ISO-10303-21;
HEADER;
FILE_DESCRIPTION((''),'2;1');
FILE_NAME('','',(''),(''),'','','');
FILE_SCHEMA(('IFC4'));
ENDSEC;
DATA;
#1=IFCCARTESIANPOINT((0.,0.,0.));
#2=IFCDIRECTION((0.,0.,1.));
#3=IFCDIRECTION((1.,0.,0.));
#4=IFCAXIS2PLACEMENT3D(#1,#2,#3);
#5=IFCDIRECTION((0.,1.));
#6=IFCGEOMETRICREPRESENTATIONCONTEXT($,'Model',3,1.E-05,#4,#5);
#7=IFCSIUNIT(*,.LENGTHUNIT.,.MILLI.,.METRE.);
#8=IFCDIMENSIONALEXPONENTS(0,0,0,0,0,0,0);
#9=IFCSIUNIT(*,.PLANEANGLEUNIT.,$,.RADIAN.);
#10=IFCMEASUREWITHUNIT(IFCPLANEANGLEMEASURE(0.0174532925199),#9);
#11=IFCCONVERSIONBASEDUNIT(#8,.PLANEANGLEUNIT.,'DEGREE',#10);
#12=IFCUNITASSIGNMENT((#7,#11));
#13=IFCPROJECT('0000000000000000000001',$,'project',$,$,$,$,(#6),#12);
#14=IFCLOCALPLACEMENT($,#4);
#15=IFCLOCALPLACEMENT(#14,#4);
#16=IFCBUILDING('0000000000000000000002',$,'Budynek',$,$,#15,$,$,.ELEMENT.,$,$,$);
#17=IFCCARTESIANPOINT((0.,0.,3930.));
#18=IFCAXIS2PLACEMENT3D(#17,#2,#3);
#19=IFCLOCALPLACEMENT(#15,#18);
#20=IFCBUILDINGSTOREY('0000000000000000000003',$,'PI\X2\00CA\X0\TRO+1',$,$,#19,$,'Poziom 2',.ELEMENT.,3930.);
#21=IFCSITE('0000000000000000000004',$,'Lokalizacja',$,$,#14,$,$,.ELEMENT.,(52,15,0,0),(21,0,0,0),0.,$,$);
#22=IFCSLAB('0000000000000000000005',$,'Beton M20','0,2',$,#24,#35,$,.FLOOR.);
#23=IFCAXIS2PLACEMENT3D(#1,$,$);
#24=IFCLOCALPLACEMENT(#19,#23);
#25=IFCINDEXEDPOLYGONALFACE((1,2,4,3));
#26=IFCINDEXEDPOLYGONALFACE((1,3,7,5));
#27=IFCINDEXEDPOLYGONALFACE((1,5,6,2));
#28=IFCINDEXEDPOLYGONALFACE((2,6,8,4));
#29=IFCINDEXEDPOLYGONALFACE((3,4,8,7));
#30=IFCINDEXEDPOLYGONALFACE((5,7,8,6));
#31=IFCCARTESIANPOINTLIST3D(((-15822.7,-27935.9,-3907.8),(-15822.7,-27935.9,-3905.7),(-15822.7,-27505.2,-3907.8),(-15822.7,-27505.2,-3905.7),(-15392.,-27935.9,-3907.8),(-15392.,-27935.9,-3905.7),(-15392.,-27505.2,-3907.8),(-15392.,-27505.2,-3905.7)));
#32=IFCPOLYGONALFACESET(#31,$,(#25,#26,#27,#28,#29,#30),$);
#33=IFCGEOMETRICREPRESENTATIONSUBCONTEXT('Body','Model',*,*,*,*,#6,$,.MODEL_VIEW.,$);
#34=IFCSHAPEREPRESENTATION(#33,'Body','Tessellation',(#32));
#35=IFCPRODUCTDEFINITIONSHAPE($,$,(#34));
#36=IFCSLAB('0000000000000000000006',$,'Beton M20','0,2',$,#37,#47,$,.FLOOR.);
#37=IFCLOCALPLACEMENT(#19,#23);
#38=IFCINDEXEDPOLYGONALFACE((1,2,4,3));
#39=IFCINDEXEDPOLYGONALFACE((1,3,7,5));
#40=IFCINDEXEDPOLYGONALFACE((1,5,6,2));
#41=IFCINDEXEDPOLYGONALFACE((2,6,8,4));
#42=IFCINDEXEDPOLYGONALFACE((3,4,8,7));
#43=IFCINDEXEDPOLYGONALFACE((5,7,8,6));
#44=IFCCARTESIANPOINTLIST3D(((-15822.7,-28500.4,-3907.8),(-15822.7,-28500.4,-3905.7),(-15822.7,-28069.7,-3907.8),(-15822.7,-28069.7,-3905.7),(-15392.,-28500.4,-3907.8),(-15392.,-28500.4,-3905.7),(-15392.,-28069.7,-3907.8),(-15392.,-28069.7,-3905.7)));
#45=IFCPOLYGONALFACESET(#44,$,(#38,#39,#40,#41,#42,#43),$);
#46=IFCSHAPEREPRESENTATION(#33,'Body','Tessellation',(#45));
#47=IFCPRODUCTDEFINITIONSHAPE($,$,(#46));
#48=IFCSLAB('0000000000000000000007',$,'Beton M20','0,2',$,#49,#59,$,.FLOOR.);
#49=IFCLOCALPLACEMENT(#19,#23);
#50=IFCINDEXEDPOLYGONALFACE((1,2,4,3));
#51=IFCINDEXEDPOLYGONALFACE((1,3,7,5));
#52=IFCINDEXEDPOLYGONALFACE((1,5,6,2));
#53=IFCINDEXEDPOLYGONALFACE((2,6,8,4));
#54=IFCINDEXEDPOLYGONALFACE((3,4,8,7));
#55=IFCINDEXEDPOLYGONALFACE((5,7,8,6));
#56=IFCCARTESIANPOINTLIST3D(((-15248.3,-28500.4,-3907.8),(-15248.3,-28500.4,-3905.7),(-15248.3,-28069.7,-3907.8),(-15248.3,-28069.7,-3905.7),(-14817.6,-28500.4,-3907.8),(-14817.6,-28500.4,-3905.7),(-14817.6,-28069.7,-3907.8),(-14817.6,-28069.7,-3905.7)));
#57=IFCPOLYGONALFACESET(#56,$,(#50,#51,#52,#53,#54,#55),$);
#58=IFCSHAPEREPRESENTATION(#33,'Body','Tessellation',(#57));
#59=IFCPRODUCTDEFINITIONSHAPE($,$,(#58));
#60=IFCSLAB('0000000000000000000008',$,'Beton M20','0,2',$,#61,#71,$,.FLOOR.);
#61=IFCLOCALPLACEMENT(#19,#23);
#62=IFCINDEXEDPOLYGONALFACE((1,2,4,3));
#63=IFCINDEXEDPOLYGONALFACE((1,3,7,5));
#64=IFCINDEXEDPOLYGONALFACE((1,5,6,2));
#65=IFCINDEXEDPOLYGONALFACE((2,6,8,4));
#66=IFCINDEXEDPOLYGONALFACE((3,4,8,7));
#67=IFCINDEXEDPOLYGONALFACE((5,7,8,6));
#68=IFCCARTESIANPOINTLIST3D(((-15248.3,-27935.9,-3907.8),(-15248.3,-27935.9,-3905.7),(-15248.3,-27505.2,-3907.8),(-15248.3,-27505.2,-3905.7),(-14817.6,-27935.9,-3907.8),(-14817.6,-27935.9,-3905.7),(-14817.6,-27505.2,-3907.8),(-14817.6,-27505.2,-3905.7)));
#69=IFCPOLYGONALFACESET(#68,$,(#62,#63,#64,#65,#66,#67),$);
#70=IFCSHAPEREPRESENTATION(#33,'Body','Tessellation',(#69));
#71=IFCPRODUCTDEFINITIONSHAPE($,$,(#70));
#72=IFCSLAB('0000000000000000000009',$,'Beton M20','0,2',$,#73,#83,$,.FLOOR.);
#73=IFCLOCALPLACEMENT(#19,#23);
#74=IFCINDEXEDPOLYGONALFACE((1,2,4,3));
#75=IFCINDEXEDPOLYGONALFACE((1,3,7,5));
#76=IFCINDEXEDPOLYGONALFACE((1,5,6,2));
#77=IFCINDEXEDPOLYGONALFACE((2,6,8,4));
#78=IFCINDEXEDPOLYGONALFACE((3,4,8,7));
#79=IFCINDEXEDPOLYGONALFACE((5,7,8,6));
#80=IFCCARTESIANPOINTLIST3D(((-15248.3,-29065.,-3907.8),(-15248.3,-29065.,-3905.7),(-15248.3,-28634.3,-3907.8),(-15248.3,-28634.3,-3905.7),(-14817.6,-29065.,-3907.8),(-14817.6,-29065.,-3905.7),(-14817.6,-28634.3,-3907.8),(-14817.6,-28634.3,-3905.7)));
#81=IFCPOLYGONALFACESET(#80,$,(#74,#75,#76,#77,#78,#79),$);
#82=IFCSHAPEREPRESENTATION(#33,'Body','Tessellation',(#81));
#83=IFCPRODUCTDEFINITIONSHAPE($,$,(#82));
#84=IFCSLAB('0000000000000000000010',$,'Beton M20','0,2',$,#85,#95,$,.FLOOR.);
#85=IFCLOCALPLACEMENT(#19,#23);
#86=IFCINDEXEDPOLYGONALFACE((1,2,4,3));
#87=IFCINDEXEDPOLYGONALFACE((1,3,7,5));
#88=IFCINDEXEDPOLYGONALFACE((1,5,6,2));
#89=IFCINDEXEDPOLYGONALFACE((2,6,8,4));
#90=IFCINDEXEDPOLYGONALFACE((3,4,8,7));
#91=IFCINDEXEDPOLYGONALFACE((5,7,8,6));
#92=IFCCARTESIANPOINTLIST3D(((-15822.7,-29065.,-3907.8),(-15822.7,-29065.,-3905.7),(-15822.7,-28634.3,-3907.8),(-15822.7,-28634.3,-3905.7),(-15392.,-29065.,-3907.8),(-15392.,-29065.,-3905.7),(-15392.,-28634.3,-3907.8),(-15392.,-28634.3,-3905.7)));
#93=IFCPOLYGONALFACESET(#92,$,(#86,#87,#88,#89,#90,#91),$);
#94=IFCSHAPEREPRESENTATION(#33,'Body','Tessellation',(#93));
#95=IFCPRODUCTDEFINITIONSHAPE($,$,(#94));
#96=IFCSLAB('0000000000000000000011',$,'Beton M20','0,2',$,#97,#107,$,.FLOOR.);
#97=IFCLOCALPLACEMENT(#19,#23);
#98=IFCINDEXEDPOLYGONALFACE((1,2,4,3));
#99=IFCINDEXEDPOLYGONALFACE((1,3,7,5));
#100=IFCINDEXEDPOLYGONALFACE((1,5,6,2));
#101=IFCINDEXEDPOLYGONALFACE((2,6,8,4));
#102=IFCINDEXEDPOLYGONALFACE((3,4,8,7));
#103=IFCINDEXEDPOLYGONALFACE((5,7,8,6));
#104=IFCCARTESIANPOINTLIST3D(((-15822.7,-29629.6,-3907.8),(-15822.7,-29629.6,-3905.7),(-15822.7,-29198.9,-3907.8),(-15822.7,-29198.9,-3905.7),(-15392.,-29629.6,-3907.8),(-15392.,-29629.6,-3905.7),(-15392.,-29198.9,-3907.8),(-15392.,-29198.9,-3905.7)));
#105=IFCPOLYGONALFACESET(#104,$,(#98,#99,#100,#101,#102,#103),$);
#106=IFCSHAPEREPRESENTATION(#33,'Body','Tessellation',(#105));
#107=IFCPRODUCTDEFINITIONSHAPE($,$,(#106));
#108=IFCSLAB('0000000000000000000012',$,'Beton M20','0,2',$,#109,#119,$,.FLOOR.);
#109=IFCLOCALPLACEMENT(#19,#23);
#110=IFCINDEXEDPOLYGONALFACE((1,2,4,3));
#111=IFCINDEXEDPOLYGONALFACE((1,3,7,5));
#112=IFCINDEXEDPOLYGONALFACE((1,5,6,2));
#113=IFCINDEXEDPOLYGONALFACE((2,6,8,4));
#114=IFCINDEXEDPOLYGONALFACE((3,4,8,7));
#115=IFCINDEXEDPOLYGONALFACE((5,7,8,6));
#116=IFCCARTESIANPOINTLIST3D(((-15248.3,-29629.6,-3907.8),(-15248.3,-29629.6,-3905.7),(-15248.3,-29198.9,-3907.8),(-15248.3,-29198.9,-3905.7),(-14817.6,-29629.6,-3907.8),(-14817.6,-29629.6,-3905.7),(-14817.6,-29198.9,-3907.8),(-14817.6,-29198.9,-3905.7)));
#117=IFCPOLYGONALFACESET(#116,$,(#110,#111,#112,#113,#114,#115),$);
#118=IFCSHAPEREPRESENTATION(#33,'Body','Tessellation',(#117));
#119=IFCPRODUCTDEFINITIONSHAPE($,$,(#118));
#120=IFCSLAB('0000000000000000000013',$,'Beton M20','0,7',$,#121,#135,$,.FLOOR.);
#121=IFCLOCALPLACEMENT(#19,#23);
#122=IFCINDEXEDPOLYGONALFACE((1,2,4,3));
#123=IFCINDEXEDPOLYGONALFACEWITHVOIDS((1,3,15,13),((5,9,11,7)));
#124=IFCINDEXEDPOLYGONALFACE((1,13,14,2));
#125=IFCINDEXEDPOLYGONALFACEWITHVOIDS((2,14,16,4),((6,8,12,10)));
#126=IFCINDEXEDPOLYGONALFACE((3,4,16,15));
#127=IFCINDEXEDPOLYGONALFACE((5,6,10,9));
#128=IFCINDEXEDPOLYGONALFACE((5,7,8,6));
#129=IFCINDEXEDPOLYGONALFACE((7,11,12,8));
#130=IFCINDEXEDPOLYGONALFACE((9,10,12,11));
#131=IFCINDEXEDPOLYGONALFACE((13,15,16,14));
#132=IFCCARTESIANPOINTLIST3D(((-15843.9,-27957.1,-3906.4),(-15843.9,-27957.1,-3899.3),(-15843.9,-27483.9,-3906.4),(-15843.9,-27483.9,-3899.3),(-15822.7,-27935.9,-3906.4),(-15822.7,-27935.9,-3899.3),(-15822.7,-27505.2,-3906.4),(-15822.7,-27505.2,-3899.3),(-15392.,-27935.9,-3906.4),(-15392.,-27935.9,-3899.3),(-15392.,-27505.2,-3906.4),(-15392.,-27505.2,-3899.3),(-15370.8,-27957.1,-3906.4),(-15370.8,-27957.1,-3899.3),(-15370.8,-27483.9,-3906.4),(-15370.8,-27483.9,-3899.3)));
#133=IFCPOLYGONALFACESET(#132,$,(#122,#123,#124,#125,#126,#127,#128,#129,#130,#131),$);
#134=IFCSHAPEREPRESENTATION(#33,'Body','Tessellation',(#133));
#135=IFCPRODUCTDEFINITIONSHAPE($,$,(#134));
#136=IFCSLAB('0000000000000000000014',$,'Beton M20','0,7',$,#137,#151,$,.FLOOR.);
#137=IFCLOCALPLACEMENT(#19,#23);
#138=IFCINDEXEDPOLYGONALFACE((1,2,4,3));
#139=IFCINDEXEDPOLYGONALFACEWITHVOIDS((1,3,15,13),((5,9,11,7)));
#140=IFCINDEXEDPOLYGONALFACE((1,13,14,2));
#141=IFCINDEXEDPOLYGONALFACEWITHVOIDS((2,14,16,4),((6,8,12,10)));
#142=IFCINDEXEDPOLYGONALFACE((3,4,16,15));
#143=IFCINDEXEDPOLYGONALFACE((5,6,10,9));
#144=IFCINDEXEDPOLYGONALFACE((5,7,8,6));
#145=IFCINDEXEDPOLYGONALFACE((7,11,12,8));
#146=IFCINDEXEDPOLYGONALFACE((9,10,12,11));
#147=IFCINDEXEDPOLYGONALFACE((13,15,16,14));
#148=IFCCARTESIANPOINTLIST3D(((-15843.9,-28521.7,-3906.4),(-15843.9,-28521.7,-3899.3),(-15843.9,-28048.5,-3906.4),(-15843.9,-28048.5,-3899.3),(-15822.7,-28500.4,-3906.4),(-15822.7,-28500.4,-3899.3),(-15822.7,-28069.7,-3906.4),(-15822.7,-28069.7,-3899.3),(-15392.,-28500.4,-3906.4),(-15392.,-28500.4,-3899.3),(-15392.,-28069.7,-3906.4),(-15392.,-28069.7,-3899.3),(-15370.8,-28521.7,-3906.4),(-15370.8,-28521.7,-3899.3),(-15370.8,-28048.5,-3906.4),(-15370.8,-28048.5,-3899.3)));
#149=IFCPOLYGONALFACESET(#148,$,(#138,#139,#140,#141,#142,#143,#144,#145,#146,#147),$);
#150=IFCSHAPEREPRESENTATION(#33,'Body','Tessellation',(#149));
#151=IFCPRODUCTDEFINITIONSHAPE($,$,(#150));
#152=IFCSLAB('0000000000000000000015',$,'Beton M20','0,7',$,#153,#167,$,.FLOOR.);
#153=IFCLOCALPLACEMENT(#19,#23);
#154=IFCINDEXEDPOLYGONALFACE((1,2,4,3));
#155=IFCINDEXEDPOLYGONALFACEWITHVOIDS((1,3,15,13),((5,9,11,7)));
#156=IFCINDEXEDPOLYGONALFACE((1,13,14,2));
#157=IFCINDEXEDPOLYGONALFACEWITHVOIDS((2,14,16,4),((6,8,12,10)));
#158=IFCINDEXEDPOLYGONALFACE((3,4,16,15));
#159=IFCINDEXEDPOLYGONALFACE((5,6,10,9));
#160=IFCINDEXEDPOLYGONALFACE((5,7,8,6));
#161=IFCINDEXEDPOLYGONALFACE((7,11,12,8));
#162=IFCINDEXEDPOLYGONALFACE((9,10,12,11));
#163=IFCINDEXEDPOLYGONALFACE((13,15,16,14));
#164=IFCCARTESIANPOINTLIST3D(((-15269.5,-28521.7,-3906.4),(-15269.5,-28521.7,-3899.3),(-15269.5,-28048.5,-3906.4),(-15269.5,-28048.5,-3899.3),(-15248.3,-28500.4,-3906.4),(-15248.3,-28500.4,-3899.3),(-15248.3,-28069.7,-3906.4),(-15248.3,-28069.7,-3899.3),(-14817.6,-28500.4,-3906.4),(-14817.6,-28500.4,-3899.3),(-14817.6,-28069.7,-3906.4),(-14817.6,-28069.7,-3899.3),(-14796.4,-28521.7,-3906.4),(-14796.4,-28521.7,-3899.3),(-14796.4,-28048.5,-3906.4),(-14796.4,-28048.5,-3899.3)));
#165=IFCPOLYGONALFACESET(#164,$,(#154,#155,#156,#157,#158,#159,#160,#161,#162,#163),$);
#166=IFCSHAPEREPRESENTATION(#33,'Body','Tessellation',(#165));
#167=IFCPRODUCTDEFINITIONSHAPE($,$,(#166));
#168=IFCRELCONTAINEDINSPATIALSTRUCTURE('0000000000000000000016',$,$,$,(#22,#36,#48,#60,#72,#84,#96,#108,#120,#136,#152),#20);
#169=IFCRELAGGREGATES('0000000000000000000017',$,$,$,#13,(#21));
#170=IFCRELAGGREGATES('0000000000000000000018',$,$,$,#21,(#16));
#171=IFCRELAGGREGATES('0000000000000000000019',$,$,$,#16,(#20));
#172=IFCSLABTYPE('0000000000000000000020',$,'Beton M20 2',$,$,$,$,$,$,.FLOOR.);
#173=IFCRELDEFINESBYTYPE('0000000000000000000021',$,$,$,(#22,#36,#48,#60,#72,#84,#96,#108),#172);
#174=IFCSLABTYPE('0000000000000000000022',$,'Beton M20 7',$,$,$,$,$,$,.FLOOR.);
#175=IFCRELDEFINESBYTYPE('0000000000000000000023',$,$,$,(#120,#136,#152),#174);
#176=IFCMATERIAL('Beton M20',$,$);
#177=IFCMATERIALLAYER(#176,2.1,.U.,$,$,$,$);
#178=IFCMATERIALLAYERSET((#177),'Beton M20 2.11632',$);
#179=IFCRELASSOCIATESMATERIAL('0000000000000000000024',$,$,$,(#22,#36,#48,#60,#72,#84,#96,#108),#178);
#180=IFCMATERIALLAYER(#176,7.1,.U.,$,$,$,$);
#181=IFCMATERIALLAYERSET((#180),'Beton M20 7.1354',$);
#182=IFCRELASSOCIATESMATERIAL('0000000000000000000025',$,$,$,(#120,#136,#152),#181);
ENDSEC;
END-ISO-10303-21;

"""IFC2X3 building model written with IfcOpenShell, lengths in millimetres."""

from ifc_helpers import new_model, entity, si_unit, converted_unit, direction, frame, origin_with_axes, place, context, subcontext, project, spatial, polyline, outline, extrude, material, layer, layer_set, layer_usage, type_object, element, save


model = new_model("IFC2X3")

# Units and contexts
model_context = context("Model", 3, precision=1e-05, world=origin_with_axes(), true_north=direction((0.0, 1.0)))
body_context = subcontext(model_context, "Body", "Model", "MODEL_VIEW")
ifc_project = project(units=[si_unit("LENGTHUNIT", "METRE", prefix="MILLI"), converted_unit("PLANEANGLEUNIT", "DEGREE", entity("IfcPlaneAngleMeasure", 0.0174532925199), si_unit("PLANEANGLEUNIT", "RADIAN"), dimensions=[0, 0, 0, 0, 0, 0, 0])], contexts=[model_context])

# Site, building, storey
site_placement = place(None, origin_with_axes())
site = spatial("IfcSite", under=ifc_project, at=site_placement, Name="Lokalizacja", CompositionType="ELEMENT", RefLatitude=(52, 15, 0, 0), RefLongitude=(21, 0, 0, 0), RefElevation=0.0)
building_placement = place(site_placement, origin_with_axes())
building = spatial("IfcBuilding", under=site, at=building_placement, Name="Budynek", CompositionType="ELEMENT")
storey_placement = place(building_placement, frame((0.0, 0.0, 3930.0), z_axis=(0.0, 0.0, 1.0), x_axis=(1.0, 0.0, 0.0)))
storey = spatial("IfcBuildingStorey", under=building, at=storey_placement, Name="PIÊTRO+1", LongName="Poziom 2", CompositionType="ELEMENT", Elevation=3930.0)

# Slabs
ifc_material_1 = material(Name="Beton M20")
ifc_layer_1 = layer(ifc_material_1, 2.1, ventilated="UNKNOWN")
ifc_layer_set_1 = layer_set([ifc_layer_1], Name="Beton M20 2.11632")
ifc_layer_usage_1 = layer_usage(ifc_layer_set_1, "AXIS3", "NEGATIVE", 2.1)
slab_type_1 = type_object("IfcSlabType", Name="Beton M20 2", PredefinedType="FLOOR")
slab_1_placement = place(storey_placement, frame((-15822.7, -27505.2, -3905.7), z_axis=(0.0, 0.0, 1.0), x_axis=(1.0, 0.0, 0.0)))
element("IfcSlab", 1, at=slab_1_placement, inside=storey, type_object=slab_type_1, material=ifc_layer_usage_1, Name="Beton M20", Description="0,2", PredefinedType="FLOOR", context=body_context, shape_type="SweptSolid", body=[
    extrude(outline(polyline([(0.0, 0.0), (0.0, -430.7), (430.7, -430.7), (430.7, 0.0), (0.0, 0.0)])), frame((0.0, 0.0, -2.1), z_axis=(0.0, 0.0, 1.0), x_axis=(1.0, 0.0, 0.0)), (0.0, 0.0, 1.0), 2.1),
])
ifc_layer_usage_2 = layer_usage(ifc_layer_set_1, "AXIS3", "NEGATIVE", 2.1)
slab_2_placement = place(storey_placement, frame((-15822.7, -28069.7, -3905.7), z_axis=(0.0, 0.0, 1.0), x_axis=(1.0, 0.0, 0.0)))
element("IfcSlab", 2, at=slab_2_placement, inside=storey, type_object=slab_type_1, material=ifc_layer_usage_2, Name="Beton M20", Description="0,2", PredefinedType="FLOOR", context=body_context, shape_type="SweptSolid", body=[
    extrude(outline(polyline([(0.0, 0.0), (0.0, -430.7), (430.7, -430.7), (430.7, 0.0), (0.0, 0.0)])), frame((0.0, 0.0, -2.1), z_axis=(0.0, 0.0, 1.0), x_axis=(1.0, 0.0, 0.0)), (0.0, 0.0, 1.0), 2.1),
])
ifc_layer_usage_3 = layer_usage(ifc_layer_set_1, "AXIS3", "NEGATIVE", 2.1)
slab_3_placement = place(storey_placement, frame((-15248.3, -28069.7, -3905.7), z_axis=(0.0, 0.0, 1.0), x_axis=(1.0, 0.0, 0.0)))
element("IfcSlab", 3, at=slab_3_placement, inside=storey, type_object=slab_type_1, material=ifc_layer_usage_3, Name="Beton M20", Description="0,2", PredefinedType="FLOOR", context=body_context, shape_type="SweptSolid", body=[
    extrude(outline(polyline([(0.0, 0.0), (0.0, -430.7), (430.7, -430.7), (430.7, 0.0), (0.0, 0.0)])), frame((0.0, 0.0, -2.1), z_axis=(0.0, 0.0, 1.0), x_axis=(1.0, 0.0, 0.0)), (0.0, 0.0, 1.0), 2.1),
])
ifc_layer_usage_4 = layer_usage(ifc_layer_set_1, "AXIS3", "NEGATIVE", 2.1)
slab_4_placement = place(storey_placement, frame((-15248.3, -27505.2, -3905.7), z_axis=(0.0, 0.0, 1.0), x_axis=(1.0, 0.0, 0.0)))
element("IfcSlab", 4, at=slab_4_placement, inside=storey, type_object=slab_type_1, material=ifc_layer_usage_4, Name="Beton M20", Description="0,2", PredefinedType="FLOOR", context=body_context, shape_type="SweptSolid", body=[
    extrude(outline(polyline([(0.0, 0.0), (0.0, -430.7), (430.7, -430.7), (430.7, 0.0), (0.0, 0.0)])), frame((0.0, 0.0, -2.1), z_axis=(0.0, 0.0, 1.0), x_axis=(1.0, 0.0, 0.0)), (0.0, 0.0, 1.0), 2.1),
])
ifc_layer_usage_5 = layer_usage(ifc_layer_set_1, "AXIS3", "NEGATIVE", 2.1)
slab_5_placement = place(storey_placement, frame((-15248.3, -28634.3, -3905.7), z_axis=(0.0, 0.0, 1.0), x_axis=(1.0, 0.0, 0.0)))
element("IfcSlab", 5, at=slab_5_placement, inside=storey, type_object=slab_type_1, material=ifc_layer_usage_5, Name="Beton M20", Description="0,2", PredefinedType="FLOOR", context=body_context, shape_type="SweptSolid", body=[
    extrude(outline(polyline([(0.0, 0.0), (0.0, -430.7), (430.7, -430.7), (430.7, 0.0), (0.0, 0.0)])), frame((0.0, 0.0, -2.1), z_axis=(0.0, 0.0, 1.0), x_axis=(1.0, 0.0, 0.0)), (0.0, 0.0, 1.0), 2.1),
])
ifc_layer_usage_6 = layer_usage(ifc_layer_set_1, "AXIS3", "NEGATIVE", 2.1)
slab_6_placement = place(storey_placement, frame((-15822.7, -28634.3, -3905.7), z_axis=(0.0, 0.0, 1.0), x_axis=(1.0, 0.0, 0.0)))
element("IfcSlab", 6, at=slab_6_placement, inside=storey, type_object=slab_type_1, material=ifc_layer_usage_6, Name="Beton M20", Description="0,2", PredefinedType="FLOOR", context=body_context, shape_type="SweptSolid", body=[
    extrude(outline(polyline([(0.0, 0.0), (0.0, -430.7), (430.7, -430.7), (430.7, 0.0), (0.0, 0.0)])), frame((0.0, 0.0, -2.1), z_axis=(0.0, 0.0, 1.0), x_axis=(1.0, 0.0, 0.0)), (0.0, 0.0, 1.0), 2.1),
])
ifc_layer_usage_7 = layer_usage(ifc_layer_set_1, "AXIS3", "NEGATIVE", 2.1)
slab_7_placement = place(storey_placement, frame((-15822.7, -29198.9, -3905.7), z_axis=(0.0, 0.0, 1.0), x_axis=(1.0, 0.0, 0.0)))
element("IfcSlab", 7, at=slab_7_placement, inside=storey, type_object=slab_type_1, material=ifc_layer_usage_7, Name="Beton M20", Description="0,2", PredefinedType="FLOOR", context=body_context, shape_type="SweptSolid", body=[
    extrude(outline(polyline([(0.0, 0.0), (0.0, -430.7), (430.7, -430.7), (430.7, 0.0), (0.0, 0.0)])), frame((0.0, 0.0, -2.1), z_axis=(0.0, 0.0, 1.0), x_axis=(1.0, 0.0, 0.0)), (0.0, 0.0, 1.0), 2.1),
])
ifc_layer_usage_8 = layer_usage(ifc_layer_set_1, "AXIS3", "NEGATIVE", 2.1)
slab_8_placement = place(storey_placement, frame((-15248.3, -29198.9, -3905.7), z_axis=(0.0, 0.0, 1.0), x_axis=(1.0, 0.0, 0.0)))
element("IfcSlab", 8, at=slab_8_placement, inside=storey, type_object=slab_type_1, material=ifc_layer_usage_8, Name="Beton M20", Description="0,2", PredefinedType="FLOOR", context=body_context, shape_type="SweptSolid", body=[
    extrude(outline(polyline([(0.0, 0.0), (0.0, -430.7), (430.7, -430.7), (430.7, 0.0), (0.0, 0.0)])), frame((0.0, 0.0, -2.1), z_axis=(0.0, 0.0, 1.0), x_axis=(1.0, 0.0, 0.0)), (0.0, 0.0, 1.0), 2.1),
])

# Slabs, openings
ifc_layer_2 = layer(ifc_material_1, 7.1, ventilated="UNKNOWN")
ifc_layer_set_2 = layer_set([ifc_layer_2], Name="Beton M20 7.1354")
ifc_layer_usage_9 = layer_usage(ifc_layer_set_2, "AXIS3", "NEGATIVE", 7.1)
slab_type_2 = type_object("IfcSlabType", Name="Beton M20 7", PredefinedType="FLOOR")
slab_9_placement = place(storey_placement, frame((-15843.9, -27483.9, -3899.3), z_axis=(0.0, 0.0, 1.0), x_axis=(1.0, 0.0, 0.0)))
slab_9 = element("IfcSlab", 9, at=slab_9_placement, inside=storey, type_object=slab_type_2, material=ifc_layer_usage_9, Name="Beton M20", Description="0,7", PredefinedType="FLOOR", context=body_context, shape_type="SweptSolid", body=[
    extrude(outline(polyline([(0.0, 0.0), (0.0, -473.1), (473.1, -473.1), (473.1, 0.0), (0.0, 0.0)])), frame((0.0, 0.0, -7.1), z_axis=(0.0, 0.0, 1.0), x_axis=(1.0, 0.0, 0.0)), (0.0, 0.0, 1.0), 7.1),
])
opening_1_placement = place(slab_9_placement, origin_with_axes())
element("IfcOpeningElement", 10, at=opening_1_placement, cuts=slab_9, context=body_context, shape_type="SweptSolid", body=[
    extrude(outline(polyline([(21.2, -21.2), (21.2, -451.9), (451.9, -451.9), (451.9, -21.2), (21.2, -21.2)])), frame((0.0, 0.0, -7.1), z_axis=(0.0, 0.0, 1.0), x_axis=(1.0, 0.0, 0.0)), (0.0, 0.0, 1.0), 7.1),
])
ifc_layer_usage_10 = layer_usage(ifc_layer_set_2, "AXIS3", "NEGATIVE", 7.1)
slab_10_placement = place(storey_placement, frame((-15843.9, -28048.5, -3899.3), z_axis=(0.0, 0.0, 1.0), x_axis=(1.0, 0.0, 0.0)))
slab_10 = element("IfcSlab", 11, at=slab_10_placement, inside=storey, type_object=slab_type_2, material=ifc_layer_usage_10, Name="Beton M20", Description="0,7", PredefinedType="FLOOR", context=body_context, shape_type="SweptSolid", body=[
    extrude(outline(polyline([(0.0, 0.0), (0.0, -473.1), (473.1, -473.1), (473.1, 0.0), (0.0, 0.0)])), frame((0.0, 0.0, -7.1), z_axis=(0.0, 0.0, 1.0), x_axis=(1.0, 0.0, 0.0)), (0.0, 0.0, 1.0), 7.1),
])
opening_2_placement = place(slab_10_placement, origin_with_axes())
element("IfcOpeningElement", 12, at=opening_2_placement, cuts=slab_10, context=body_context, shape_type="SweptSolid", body=[
    extrude(outline(polyline([(21.2, -21.2), (21.2, -451.9), (451.9, -451.9), (451.9, -21.2), (21.2, -21.2)])), frame((0.0, 0.0, -7.1), z_axis=(0.0, 0.0, 1.0), x_axis=(1.0, 0.0, 0.0)), (0.0, 0.0, 1.0), 7.1),
])
ifc_layer_usage_11 = layer_usage(ifc_layer_set_2, "AXIS3", "NEGATIVE", 7.1)
slab_11_placement = place(storey_placement, frame((-15269.5, -28048.5, -3899.3), z_axis=(0.0, 0.0, 1.0), x_axis=(1.0, 0.0, 0.0)))
slab_11 = element("IfcSlab", 13, at=slab_11_placement, inside=storey, type_object=slab_type_2, material=ifc_layer_usage_11, Name="Beton M20", Description="0,7", PredefinedType="FLOOR", context=body_context, shape_type="SweptSolid", body=[
    extrude(outline(polyline([(0.0, 0.0), (0.0, -473.1), (473.1, -473.1), (473.1, 0.0), (0.0, 0.0)])), frame((0.0, 0.0, -7.1), z_axis=(0.0, 0.0, 1.0), x_axis=(1.0, 0.0, 0.0)), (0.0, 0.0, 1.0), 7.1),
])
opening_3_placement = place(slab_11_placement, origin_with_axes())
element("IfcOpeningElement", 14, at=opening_3_placement, cuts=slab_11, context=body_context, shape_type="SweptSolid", body=[
    extrude(outline(polyline([(21.2, -21.2), (21.2, -451.9), (451.9, -451.9), (451.9, -21.2), (21.2, -21.2)])), frame((0.0, 0.0, -7.1), z_axis=(0.0, 0.0, 1.0), x_axis=(1.0, 0.0, 0.0)), (0.0, 0.0, 1.0), 7.1),
])

save(model, "model.ifc")
